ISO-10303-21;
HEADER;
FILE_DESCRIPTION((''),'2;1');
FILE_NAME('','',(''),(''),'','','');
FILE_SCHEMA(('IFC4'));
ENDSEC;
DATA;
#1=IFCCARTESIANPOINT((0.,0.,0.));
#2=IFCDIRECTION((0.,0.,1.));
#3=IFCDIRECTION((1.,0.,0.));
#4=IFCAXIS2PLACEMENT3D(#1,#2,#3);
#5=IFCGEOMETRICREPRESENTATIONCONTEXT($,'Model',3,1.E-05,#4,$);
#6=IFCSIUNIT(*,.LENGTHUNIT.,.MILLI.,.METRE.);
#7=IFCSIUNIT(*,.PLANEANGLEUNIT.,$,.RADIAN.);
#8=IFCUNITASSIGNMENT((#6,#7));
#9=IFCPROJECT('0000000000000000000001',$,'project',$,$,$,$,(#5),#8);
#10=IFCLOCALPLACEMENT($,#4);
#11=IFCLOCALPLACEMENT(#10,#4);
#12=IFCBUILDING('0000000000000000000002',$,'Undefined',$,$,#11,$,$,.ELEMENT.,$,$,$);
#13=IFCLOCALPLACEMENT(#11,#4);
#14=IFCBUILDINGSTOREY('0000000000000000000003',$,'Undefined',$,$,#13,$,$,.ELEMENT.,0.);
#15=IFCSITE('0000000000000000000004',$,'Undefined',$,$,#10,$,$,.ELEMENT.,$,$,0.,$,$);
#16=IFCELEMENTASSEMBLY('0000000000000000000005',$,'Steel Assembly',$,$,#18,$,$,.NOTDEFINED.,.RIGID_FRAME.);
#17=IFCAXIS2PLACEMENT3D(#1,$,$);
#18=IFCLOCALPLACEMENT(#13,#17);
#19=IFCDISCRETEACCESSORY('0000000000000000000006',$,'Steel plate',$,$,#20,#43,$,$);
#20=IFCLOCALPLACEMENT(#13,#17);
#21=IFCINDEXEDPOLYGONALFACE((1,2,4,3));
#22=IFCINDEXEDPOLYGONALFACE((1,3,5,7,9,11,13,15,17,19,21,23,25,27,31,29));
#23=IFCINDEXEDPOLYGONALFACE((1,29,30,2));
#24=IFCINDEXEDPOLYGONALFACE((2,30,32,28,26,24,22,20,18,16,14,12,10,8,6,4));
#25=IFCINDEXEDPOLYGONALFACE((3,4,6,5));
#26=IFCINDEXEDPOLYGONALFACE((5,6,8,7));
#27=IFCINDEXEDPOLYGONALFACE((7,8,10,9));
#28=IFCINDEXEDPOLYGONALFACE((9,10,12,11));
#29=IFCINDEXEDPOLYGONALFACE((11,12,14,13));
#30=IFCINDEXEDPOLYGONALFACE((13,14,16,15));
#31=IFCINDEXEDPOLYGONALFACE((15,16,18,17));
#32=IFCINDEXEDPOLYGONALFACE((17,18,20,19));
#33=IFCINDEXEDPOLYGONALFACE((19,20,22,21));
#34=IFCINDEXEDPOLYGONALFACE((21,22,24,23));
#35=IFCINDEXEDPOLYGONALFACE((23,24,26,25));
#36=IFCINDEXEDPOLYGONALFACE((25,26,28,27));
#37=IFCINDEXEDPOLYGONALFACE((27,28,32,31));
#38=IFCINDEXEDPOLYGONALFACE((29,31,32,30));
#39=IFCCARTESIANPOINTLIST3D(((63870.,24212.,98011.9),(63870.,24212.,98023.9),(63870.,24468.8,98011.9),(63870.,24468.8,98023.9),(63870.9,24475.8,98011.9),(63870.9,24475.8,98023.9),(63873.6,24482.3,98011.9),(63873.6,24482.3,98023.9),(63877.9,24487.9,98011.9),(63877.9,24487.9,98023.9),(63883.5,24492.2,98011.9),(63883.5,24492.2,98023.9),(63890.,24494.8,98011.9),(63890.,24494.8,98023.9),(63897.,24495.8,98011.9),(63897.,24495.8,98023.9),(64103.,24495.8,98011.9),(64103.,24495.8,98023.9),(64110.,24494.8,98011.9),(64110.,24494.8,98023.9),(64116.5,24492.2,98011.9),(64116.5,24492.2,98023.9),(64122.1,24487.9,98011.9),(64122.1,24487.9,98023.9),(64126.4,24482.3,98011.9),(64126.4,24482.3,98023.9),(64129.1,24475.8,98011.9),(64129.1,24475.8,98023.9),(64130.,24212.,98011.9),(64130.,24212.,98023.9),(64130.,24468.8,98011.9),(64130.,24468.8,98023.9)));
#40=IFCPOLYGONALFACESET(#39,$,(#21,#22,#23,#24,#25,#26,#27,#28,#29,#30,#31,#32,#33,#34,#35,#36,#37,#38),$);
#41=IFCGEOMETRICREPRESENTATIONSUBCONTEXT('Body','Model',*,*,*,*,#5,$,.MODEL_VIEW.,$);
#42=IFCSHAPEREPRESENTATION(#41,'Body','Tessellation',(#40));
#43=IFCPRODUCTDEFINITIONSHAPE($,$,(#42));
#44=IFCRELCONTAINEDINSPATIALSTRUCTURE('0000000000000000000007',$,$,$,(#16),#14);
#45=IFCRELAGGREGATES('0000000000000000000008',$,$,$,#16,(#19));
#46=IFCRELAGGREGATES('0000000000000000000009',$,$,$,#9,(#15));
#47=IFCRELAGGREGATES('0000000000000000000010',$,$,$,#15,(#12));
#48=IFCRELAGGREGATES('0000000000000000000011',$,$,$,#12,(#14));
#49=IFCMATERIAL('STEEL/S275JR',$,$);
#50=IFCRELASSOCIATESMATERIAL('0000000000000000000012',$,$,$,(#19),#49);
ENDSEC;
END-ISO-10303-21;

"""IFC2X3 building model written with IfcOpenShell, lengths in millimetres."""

from ifc_helpers import new_model, si_unit, frame, frame_2d, origin_with_axes, place, context, subcontext, project, spatial, polyline, circle_curve, parameter, trimmed, segment, composite_curve, outline, extrude, material, element, aggregate, save


model = new_model("IFC2X3")

# Units and contexts
model_context = context("Model", 3, precision=1e-05, world=origin_with_axes())
body_context = subcontext(model_context, "Body", "Model", "MODEL_VIEW")
ifc_project = project(units=[si_unit("LENGTHUNIT", "METRE", prefix="MILLI"), si_unit("PLANEANGLEUNIT", "RADIAN")], contexts=[model_context])

# Site, building, storey
site_placement = place(None, origin_with_axes())
site = spatial("IfcSite", under=ifc_project, at=site_placement, Name="Undefined", CompositionType="ELEMENT", RefElevation=0.0)
building_placement = place(site_placement, origin_with_axes())
building = spatial("IfcBuilding", under=site, at=building_placement, Name="Undefined", CompositionType="ELEMENT")
storey_placement = place(building_placement, origin_with_axes())
storey = spatial("IfcBuildingStorey", under=building, at=storey_placement, Name="Undefined", CompositionType="ELEMENT", Elevation=0.0)

# Shared definitions
ifc_material_1 = material(Name="STEEL/S275JR")

# Element assembly, discrete accessory
assembly_1_placement = place(storey_placement, origin_with_axes())
assembly_1 = element("IfcElementAssembly", 1, at=assembly_1_placement, inside=storey, Name="Steel Assembly", AssemblyPlace="NOTDEFINED", PredefinedType="RIGID_FRAME")
discrete_accessory_1_placement = place(assembly_1_placement, frame((63870.0, 24495.8, 98017.9), z_axis=(0.0, 0.0, -1.0), x_axis=(1.0, 0.0, 0.0)))
discrete_accessory_1 = element("IfcDiscreteAccessory", 2, at=discrete_accessory_1_placement, material=ifc_material_1, Name="Steel plate", context=body_context, shape_type="SweptSolid", body=[
    extrude(outline(composite_curve([segment(trimmed(circle_curve(frame_2d((27.0, 27.0), x_axis=(-1.0, 0.0)), 27.0), [parameter(0.0)], [parameter(1.570796)], True, "PARAMETER"), True, "CONTINUOUS"), segment(polyline([(27.0, 0.0), (233.0, 0.0)]), True, "CONTINUOUS"), segment(trimmed(circle_curve(frame_2d((233.0, 27.0), x_axis=(0.0, -1.0)), 27.0), [parameter(0.0)], [parameter(1.570796)], True, "PARAMETER"), True, "CONTINUOUS"), segment(polyline([(260.0, 27.0), (260.0, 283.7), (0.0, 283.7), (0.0, 27.0)]), True, "DISCONTINUOUS")], self_intersect=False)), frame((0.0, 0.0, -6.0), z_axis=(0.0, 0.0, 1.0), x_axis=(1.0, 0.0, 0.0)), (0.0, 0.0, 1.0), 12.0),
])
aggregate(assembly_1, [discrete_accessory_1])

save(model, "model.ifc")
